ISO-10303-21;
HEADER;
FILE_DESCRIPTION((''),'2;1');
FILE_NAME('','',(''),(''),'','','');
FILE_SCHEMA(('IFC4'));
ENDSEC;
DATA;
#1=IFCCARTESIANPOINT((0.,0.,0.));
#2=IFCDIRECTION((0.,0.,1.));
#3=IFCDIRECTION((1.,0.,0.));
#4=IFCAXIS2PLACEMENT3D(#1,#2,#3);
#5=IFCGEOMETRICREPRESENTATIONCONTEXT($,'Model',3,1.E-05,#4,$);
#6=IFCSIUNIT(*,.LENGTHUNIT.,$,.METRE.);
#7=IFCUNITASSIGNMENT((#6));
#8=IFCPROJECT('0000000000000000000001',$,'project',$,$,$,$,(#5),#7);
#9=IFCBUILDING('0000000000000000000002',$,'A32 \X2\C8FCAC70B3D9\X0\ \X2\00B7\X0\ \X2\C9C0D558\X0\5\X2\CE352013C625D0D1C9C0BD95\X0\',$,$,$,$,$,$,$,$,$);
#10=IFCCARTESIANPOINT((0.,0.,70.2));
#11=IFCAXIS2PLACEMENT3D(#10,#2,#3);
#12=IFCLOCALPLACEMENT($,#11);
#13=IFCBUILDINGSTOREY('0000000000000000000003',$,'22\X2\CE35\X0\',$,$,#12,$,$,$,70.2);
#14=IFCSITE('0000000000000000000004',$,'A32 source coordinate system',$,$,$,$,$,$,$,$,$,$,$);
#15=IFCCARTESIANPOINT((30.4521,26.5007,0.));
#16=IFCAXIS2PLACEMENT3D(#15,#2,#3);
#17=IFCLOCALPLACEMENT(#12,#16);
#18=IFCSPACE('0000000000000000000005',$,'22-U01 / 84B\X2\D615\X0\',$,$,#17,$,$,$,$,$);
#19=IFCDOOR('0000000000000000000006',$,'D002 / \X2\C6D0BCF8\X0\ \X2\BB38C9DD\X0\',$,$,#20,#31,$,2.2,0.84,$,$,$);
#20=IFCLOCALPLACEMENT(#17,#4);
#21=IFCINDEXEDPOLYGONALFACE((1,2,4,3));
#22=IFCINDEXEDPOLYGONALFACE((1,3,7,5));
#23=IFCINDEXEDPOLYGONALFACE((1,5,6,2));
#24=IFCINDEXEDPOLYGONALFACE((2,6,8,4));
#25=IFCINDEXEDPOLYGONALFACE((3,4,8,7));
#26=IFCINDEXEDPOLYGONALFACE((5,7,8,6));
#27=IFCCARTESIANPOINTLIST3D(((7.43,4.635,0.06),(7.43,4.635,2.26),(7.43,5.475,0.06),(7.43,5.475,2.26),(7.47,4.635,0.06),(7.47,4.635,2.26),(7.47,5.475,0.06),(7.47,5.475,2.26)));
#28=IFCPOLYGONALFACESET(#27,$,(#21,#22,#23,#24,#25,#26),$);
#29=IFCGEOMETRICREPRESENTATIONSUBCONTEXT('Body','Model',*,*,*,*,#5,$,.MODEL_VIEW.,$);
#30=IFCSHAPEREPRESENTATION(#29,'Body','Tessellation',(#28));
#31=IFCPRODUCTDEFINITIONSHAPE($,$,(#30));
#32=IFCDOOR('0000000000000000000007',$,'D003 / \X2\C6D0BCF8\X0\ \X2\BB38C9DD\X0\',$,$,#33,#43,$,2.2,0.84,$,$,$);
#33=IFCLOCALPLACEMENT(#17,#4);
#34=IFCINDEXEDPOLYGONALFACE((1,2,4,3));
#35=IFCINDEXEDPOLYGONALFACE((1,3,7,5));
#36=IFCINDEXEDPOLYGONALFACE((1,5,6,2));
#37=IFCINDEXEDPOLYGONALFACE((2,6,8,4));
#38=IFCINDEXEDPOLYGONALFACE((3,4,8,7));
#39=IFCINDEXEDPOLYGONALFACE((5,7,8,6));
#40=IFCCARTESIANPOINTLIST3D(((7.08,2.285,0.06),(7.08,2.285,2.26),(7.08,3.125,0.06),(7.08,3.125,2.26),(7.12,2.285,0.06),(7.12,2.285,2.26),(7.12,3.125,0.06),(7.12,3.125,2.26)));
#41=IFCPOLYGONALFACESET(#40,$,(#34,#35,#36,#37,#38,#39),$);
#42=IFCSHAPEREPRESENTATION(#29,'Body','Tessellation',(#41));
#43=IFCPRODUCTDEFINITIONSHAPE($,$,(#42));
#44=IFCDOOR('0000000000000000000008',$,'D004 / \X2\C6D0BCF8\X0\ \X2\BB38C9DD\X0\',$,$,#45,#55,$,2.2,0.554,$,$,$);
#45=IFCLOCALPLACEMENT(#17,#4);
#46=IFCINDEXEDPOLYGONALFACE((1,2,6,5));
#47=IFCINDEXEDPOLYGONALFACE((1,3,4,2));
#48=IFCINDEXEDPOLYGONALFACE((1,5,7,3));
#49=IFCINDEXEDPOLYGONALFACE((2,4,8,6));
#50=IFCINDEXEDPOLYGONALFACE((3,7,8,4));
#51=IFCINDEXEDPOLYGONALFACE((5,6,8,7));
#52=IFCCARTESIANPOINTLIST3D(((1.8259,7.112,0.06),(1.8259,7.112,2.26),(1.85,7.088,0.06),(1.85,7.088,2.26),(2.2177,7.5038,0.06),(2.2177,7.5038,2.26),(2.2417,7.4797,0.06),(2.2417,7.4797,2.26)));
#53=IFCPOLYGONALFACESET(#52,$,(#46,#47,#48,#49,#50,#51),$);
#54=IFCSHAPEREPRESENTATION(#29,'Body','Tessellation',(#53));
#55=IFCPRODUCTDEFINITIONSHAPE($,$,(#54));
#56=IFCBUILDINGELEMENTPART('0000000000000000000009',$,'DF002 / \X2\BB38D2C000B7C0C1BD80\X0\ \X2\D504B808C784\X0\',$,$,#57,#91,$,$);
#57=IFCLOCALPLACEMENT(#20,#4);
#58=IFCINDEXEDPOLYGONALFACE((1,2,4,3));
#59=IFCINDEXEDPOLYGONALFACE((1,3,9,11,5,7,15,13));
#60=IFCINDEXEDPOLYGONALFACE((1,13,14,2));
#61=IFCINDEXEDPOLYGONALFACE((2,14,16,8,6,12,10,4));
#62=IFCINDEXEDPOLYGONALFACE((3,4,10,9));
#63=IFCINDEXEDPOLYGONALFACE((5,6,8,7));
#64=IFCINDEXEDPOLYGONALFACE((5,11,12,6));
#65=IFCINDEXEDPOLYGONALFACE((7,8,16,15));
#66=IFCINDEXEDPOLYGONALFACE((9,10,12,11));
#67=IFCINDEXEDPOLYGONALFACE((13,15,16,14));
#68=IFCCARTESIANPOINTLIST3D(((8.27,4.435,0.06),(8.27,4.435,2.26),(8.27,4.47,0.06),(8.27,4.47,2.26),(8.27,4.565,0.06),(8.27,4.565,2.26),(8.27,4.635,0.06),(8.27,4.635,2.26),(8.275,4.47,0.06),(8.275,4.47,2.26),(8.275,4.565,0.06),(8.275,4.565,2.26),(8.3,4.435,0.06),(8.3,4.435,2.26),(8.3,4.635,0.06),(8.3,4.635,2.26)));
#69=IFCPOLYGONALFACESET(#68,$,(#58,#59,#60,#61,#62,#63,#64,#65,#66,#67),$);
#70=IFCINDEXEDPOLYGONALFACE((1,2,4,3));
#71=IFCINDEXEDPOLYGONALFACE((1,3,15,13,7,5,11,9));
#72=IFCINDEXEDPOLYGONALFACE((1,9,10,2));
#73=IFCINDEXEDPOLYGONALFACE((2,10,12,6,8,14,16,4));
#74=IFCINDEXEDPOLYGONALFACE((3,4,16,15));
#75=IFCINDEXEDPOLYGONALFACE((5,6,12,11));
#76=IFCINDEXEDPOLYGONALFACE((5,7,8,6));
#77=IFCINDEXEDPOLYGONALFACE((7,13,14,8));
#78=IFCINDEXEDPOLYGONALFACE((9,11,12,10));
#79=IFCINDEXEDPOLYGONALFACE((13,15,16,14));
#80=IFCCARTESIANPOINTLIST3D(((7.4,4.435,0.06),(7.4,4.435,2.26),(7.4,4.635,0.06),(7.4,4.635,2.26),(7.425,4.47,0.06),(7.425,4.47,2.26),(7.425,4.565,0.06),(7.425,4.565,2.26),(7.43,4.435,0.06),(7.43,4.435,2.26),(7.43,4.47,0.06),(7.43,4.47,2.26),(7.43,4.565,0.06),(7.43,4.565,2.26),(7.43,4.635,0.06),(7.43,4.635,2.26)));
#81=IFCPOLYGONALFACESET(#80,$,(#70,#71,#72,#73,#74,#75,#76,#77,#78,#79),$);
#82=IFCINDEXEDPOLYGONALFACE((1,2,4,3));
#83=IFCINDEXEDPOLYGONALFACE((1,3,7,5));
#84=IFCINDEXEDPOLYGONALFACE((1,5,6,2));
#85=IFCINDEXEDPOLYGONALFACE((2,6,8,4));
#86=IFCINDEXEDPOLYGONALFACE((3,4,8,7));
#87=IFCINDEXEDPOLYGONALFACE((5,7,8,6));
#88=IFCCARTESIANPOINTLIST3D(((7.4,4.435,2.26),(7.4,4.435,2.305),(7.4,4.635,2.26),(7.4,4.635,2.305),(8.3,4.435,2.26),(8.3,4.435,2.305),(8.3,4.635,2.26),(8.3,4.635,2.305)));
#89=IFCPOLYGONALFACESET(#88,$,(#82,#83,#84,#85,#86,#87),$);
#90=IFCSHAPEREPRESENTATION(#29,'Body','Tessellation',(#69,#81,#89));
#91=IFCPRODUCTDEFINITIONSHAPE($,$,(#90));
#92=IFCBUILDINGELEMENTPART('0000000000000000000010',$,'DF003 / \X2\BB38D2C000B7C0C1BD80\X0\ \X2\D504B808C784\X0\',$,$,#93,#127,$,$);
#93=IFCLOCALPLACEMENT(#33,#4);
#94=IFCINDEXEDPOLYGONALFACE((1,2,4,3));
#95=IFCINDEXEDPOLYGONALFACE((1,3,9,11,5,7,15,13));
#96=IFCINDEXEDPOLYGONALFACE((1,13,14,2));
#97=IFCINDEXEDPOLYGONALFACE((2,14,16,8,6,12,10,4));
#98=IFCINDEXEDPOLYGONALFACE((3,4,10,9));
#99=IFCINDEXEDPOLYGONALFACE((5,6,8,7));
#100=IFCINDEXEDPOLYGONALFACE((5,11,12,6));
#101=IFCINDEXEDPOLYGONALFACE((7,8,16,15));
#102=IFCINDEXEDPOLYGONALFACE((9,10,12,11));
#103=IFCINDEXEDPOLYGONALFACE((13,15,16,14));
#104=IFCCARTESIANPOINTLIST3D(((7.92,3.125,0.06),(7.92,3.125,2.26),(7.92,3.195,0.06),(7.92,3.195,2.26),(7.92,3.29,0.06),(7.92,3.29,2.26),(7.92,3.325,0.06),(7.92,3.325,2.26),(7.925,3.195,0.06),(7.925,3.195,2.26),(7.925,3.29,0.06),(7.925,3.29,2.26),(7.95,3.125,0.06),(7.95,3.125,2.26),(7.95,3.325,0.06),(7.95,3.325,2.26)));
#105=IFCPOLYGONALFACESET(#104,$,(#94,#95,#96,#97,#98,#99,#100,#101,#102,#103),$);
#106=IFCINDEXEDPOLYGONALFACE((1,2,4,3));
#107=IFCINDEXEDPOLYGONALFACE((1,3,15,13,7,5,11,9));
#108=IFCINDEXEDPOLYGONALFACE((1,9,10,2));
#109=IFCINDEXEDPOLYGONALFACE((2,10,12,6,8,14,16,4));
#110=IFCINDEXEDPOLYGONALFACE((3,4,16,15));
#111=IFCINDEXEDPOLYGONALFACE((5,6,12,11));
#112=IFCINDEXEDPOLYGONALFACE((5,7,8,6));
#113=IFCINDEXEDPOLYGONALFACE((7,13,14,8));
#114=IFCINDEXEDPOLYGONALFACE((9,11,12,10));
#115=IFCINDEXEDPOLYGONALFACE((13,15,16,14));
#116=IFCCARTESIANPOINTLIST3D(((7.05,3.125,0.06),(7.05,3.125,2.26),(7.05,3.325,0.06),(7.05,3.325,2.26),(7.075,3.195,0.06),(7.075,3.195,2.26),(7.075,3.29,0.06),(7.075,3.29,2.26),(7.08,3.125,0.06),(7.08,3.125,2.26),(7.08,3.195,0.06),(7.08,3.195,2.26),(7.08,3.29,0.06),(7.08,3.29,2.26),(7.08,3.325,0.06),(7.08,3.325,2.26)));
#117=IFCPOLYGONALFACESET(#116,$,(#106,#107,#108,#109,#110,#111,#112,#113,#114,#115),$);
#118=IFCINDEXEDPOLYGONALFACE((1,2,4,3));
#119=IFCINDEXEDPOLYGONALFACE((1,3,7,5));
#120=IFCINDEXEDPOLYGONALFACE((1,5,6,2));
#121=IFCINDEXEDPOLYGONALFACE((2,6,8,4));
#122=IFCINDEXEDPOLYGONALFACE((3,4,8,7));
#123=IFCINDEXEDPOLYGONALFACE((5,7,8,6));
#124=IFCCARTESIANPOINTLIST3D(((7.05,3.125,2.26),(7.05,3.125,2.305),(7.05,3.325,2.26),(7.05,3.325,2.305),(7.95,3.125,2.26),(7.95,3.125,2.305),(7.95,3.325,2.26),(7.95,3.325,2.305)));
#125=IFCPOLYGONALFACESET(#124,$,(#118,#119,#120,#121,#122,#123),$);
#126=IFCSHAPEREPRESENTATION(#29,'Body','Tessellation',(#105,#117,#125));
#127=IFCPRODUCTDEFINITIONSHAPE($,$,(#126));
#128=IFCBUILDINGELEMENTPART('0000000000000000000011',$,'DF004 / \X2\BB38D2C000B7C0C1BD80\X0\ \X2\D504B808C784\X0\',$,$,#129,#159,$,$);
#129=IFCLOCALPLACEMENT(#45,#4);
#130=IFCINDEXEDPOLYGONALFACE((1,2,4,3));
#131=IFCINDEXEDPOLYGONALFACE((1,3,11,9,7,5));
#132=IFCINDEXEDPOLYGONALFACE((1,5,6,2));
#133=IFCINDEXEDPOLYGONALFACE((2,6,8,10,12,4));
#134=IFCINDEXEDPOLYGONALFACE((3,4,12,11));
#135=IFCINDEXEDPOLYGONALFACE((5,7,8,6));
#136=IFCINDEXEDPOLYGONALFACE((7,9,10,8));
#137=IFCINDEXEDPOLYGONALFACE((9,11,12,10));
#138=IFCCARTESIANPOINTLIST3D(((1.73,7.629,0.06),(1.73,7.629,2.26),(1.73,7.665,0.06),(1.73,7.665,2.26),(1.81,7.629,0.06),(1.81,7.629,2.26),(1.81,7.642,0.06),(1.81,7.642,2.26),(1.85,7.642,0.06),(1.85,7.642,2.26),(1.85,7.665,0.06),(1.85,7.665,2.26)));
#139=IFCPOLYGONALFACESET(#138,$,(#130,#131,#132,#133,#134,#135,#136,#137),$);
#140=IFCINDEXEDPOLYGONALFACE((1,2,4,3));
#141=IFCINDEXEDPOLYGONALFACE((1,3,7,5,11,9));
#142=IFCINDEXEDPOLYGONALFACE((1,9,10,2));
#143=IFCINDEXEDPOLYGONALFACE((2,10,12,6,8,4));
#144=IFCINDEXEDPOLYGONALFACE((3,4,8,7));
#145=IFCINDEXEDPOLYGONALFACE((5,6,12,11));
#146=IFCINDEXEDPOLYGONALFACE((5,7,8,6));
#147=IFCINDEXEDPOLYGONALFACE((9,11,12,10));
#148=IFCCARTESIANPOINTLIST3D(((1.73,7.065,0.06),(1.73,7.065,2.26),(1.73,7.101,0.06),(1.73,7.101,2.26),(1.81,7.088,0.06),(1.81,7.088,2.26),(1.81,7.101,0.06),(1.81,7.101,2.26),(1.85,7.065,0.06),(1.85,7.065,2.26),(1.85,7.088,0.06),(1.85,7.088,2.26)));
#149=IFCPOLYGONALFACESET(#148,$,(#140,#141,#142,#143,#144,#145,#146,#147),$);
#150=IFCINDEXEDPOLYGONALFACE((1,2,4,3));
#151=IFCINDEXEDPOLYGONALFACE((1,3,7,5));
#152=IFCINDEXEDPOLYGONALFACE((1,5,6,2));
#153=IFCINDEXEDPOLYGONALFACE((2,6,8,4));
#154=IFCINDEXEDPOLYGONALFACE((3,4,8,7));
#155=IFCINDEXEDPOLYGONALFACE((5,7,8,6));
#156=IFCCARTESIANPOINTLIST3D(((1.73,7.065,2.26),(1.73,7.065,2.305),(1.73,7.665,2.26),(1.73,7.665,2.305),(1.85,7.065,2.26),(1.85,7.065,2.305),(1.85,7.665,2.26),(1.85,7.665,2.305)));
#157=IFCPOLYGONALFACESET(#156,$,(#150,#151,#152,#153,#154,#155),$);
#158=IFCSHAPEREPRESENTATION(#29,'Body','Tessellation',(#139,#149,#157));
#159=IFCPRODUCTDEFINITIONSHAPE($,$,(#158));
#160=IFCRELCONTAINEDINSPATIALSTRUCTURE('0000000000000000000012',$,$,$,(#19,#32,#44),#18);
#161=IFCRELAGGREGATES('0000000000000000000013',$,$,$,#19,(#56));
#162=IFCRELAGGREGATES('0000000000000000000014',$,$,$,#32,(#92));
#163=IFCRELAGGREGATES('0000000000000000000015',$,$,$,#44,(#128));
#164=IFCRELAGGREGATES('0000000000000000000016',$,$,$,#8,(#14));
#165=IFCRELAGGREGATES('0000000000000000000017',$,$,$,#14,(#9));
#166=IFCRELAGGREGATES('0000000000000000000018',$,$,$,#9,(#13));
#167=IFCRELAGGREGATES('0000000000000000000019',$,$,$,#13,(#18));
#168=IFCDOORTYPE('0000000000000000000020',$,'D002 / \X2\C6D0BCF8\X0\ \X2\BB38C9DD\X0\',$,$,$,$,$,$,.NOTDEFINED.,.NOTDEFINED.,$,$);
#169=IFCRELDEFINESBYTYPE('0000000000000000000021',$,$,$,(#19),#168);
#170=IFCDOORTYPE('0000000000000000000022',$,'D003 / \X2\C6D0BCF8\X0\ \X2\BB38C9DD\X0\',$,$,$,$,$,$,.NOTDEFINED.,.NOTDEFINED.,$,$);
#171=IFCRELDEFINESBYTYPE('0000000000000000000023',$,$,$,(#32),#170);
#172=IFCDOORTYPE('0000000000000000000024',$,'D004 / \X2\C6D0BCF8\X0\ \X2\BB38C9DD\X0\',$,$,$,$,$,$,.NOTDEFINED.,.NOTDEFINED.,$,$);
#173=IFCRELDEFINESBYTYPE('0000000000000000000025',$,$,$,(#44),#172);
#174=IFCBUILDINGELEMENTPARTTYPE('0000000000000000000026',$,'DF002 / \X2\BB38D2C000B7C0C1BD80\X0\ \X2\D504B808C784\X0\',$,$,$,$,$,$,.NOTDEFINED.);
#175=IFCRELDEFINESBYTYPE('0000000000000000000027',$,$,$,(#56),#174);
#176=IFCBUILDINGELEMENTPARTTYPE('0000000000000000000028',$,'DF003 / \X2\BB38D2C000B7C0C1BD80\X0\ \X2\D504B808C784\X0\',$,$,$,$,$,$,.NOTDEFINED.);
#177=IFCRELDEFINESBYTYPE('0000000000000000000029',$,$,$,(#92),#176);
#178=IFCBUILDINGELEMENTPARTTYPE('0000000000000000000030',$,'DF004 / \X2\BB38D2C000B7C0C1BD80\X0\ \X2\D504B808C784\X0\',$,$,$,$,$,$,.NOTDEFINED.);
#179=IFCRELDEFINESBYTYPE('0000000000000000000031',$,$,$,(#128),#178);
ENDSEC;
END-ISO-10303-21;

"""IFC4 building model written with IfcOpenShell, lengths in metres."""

from ifc_helpers import new_model, si_unit, frame, origin, origin_with_axes, place, context, subcontext, project, spatial, polyline, outline, extrude, source, transform, mapped, type_object, type_shapes, element, aggregate, save


model = new_model("IFC4")

# Units and contexts
model_context = context("Model", 3, precision=1e-05, world=origin_with_axes())
body_context = subcontext(model_context, "Body", "Model", "MODEL_VIEW")
ifc_project = project(units=[si_unit("LENGTHUNIT", "METRE")], contexts=[model_context])

# Site, building, storey, space
storey_placement = place(None, frame((0.0, 0.0, 70.2), z_axis=(0.0, 0.0, 1.0), x_axis=(1.0, 0.0, 0.0)))
space_placement = place(storey_placement, frame((30.4521, 26.5007, 0.0), z_axis=(0.0, 0.0, 1.0), x_axis=(1.0, 0.0, 0.0)))
site = spatial("IfcSite", under=ifc_project, Name="A32 source coordinate system")
building = spatial("IfcBuilding", under=site, Name="A32 주거동 · 지하5층–옥탑지붕")
storey = spatial("IfcBuildingStorey", under=building, at=storey_placement, Name="22층", Elevation=70.2)
space = spatial("IfcSpace", under=storey, at=space_placement, Name="22-U01 / 84B형")

# Doors
door_type_1 = type_object("IfcDoorType", Name="D002 / 원본 문짝", OperationType="NOTDEFINED", PredefinedType="NOTDEFINED")
shared_shape_1 = source(origin(), body_context, "Body", "SweptSolid", [
    extrude(outline(polyline([(7.43, 4.635), (7.43, 5.475), (7.47, 5.475), (7.47, 4.635), (7.43, 4.635)])), frame((0.0, 0.0, 0.06)), (0.0, 0.0, 1.0), 2.2),
])
type_shapes(door_type_1, [shared_shape_1])
door_1_placement = place(space_placement, origin_with_axes())
door_1 = element("IfcDoor", 1, at=door_1_placement, inside=space, type_object=door_type_1, Name="D002 / 원본 문짝", OverallHeight=2.2, OverallWidth=0.84, context=body_context, shape_type="MappedRepresentation", body=[
    mapped(shared_shape_1, transform((0.0, 0.0, 0.0), scale=1.0)),
])
door_type_2 = type_object("IfcDoorType", Name="D003 / 원본 문짝", OperationType="NOTDEFINED", PredefinedType="NOTDEFINED")
shared_shape_2 = source(origin(), body_context, "Body", "SweptSolid", [
    extrude(outline(polyline([(7.12, 2.285), (7.08, 2.285), (7.08, 3.125), (7.12, 3.125), (7.12, 2.285)])), frame((0.0, 0.0, 0.06)), (0.0, 0.0, 1.0), 2.2),
])
type_shapes(door_type_2, [shared_shape_2])
door_2_placement = place(space_placement, origin_with_axes())
door_2 = element("IfcDoor", 2, at=door_2_placement, inside=space, type_object=door_type_2, Name="D003 / 원본 문짝", OverallHeight=2.2, OverallWidth=0.84, context=body_context, shape_type="MappedRepresentation", body=[
    mapped(shared_shape_2, transform((0.0, 0.0, 0.0), scale=1.0)),
])
door_type_3 = type_object("IfcDoorType", Name="D004 / 원본 문짝", OperationType="NOTDEFINED", PredefinedType="NOTDEFINED")
shared_shape_3 = source(origin(), body_context, "Body", "SweptSolid", [
    extrude(outline(polyline([(2.2177, 7.5038), (2.2417, 7.4797), (1.85, 7.088), (1.8259, 7.112), (2.2177, 7.5038)])), frame((0.0, 0.0, 0.06)), (0.0, 0.0, 1.0), 2.2),
])
type_shapes(door_type_3, [shared_shape_3])
door_3_placement = place(space_placement, origin_with_axes())
door_3 = element("IfcDoor", 3, at=door_3_placement, inside=space, type_object=door_type_3, Name="D004 / 원본 문짝", OverallHeight=2.2, OverallWidth=0.554, context=body_context, shape_type="MappedRepresentation", body=[
    mapped(shared_shape_3, transform((0.0, 0.0, 0.0), scale=1.0)),
])

# Building element parts
building_element_part_type_1 = type_object("IfcBuildingElementPartType", Name="DF002 / 문틀·상부 프레임", PredefinedType="NOTDEFINED")
shared_shape_4 = source(origin(), body_context, "Body", "SweptSolid", [
    extrude(outline(polyline([(8.3, 4.435), (8.27, 4.435), (8.27, 4.47), (8.275, 4.47), (8.275, 4.565), (8.27, 4.565), (8.27, 4.635), (8.3, 4.635), (8.3, 4.435)])), frame((0.0, 0.0, 0.06)), (0.0, 0.0, 1.0), 2.2),
    extrude(outline(polyline([(7.43, 4.635), (7.43, 4.565), (7.425, 4.565), (7.425, 4.47), (7.43, 4.47), (7.43, 4.435), (7.4, 4.435), (7.4, 4.635), (7.43, 4.635)])), frame((0.0, 0.0, 0.06)), (0.0, 0.0, 1.0), 2.2),
    extrude(outline(polyline([(7.4, 4.435), (7.4, 4.635), (8.3, 4.635), (8.3, 4.435), (7.4, 4.435)])), frame((0.0, 0.0, 2.26)), (0.0, 0.0, 1.0), 0.045),
])
type_shapes(building_element_part_type_1, [shared_shape_4])
building_element_part_1_placement = place(door_1_placement, origin_with_axes())
building_element_part_1 = element("IfcBuildingElementPart", 4, at=building_element_part_1_placement, type_object=building_element_part_type_1, Name="DF002 / 문틀·상부 프레임", context=body_context, shape_type="MappedRepresentation", body=[
    mapped(shared_shape_4, transform((0.0, 0.0, 0.0), scale=1.0)),
])
aggregate(door_1, [building_element_part_1])
building_element_part_type_2 = type_object("IfcBuildingElementPartType", Name="DF003 / 문틀·상부 프레임", PredefinedType="NOTDEFINED")
shared_shape_5 = source(origin(), body_context, "Body", "SweptSolid", [
    extrude(outline(polyline([(7.92, 3.125), (7.92, 3.195), (7.925, 3.195), (7.925, 3.29), (7.92, 3.29), (7.92, 3.325), (7.95, 3.325), (7.95, 3.125), (7.92, 3.125)])), frame((0.0, 0.0, 0.06)), (0.0, 0.0, 1.0), 2.2),
    extrude(outline(polyline([(7.05, 3.325), (7.08, 3.325), (7.08, 3.29), (7.075, 3.29), (7.075, 3.195), (7.08, 3.195), (7.08, 3.125), (7.05, 3.125), (7.05, 3.325)])), frame((0.0, 0.0, 0.06)), (0.0, 0.0, 1.0), 2.2),
    extrude(outline(polyline([(7.05, 3.125), (7.05, 3.325), (7.95, 3.325), (7.95, 3.125), (7.05, 3.125)])), frame((0.0, 0.0, 2.26)), (0.0, 0.0, 1.0), 0.045),
])
type_shapes(building_element_part_type_2, [shared_shape_5])
building_element_part_2_placement = place(door_2_placement, origin_with_axes())
building_element_part_2 = element("IfcBuildingElementPart", 5, at=building_element_part_2_placement, type_object=building_element_part_type_2, Name="DF003 / 문틀·상부 프레임", context=body_context, shape_type="MappedRepresentation", body=[
    mapped(shared_shape_5, transform((0.0, 0.0, 0.0), scale=1.0)),
])
aggregate(door_2, [building_element_part_2])
building_element_part_type_3 = type_object("IfcBuildingElementPartType", Name="DF004 / 문틀·상부 프레임", PredefinedType="NOTDEFINED")
shared_shape_6 = source(origin(), body_context, "Body", "SweptSolid", [
    extrude(outline(polyline([(1.85, 7.665), (1.85, 7.642), (1.81, 7.642), (1.81, 7.629), (1.73, 7.629), (1.73, 7.665), (1.85, 7.665)])), frame((0.0, 0.0, 0.06)), (0.0, 0.0, 1.0), 2.2),
    extrude(outline(polyline([(1.73, 7.101), (1.81, 7.101), (1.81, 7.088), (1.85, 7.088), (1.85, 7.065), (1.73, 7.065), (1.73, 7.101)])), frame((0.0, 0.0, 0.06)), (0.0, 0.0, 1.0), 2.2),
    extrude(outline(polyline([(1.73, 7.065), (1.73, 7.665), (1.85, 7.665), (1.85, 7.065), (1.73, 7.065)])), frame((0.0, 0.0, 2.26)), (0.0, 0.0, 1.0), 0.045),
])
type_shapes(building_element_part_type_3, [shared_shape_6])
building_element_part_3_placement = place(door_3_placement, origin_with_axes())
building_element_part_3 = element("IfcBuildingElementPart", 6, at=building_element_part_3_placement, type_object=building_element_part_type_3, Name="DF004 / 문틀·상부 프레임", context=body_context, shape_type="MappedRepresentation", body=[
    mapped(shared_shape_6, transform((0.0, 0.0, 0.0), scale=1.0)),
])
aggregate(door_3, [building_element_part_3])

save(model, "model.ifc")
